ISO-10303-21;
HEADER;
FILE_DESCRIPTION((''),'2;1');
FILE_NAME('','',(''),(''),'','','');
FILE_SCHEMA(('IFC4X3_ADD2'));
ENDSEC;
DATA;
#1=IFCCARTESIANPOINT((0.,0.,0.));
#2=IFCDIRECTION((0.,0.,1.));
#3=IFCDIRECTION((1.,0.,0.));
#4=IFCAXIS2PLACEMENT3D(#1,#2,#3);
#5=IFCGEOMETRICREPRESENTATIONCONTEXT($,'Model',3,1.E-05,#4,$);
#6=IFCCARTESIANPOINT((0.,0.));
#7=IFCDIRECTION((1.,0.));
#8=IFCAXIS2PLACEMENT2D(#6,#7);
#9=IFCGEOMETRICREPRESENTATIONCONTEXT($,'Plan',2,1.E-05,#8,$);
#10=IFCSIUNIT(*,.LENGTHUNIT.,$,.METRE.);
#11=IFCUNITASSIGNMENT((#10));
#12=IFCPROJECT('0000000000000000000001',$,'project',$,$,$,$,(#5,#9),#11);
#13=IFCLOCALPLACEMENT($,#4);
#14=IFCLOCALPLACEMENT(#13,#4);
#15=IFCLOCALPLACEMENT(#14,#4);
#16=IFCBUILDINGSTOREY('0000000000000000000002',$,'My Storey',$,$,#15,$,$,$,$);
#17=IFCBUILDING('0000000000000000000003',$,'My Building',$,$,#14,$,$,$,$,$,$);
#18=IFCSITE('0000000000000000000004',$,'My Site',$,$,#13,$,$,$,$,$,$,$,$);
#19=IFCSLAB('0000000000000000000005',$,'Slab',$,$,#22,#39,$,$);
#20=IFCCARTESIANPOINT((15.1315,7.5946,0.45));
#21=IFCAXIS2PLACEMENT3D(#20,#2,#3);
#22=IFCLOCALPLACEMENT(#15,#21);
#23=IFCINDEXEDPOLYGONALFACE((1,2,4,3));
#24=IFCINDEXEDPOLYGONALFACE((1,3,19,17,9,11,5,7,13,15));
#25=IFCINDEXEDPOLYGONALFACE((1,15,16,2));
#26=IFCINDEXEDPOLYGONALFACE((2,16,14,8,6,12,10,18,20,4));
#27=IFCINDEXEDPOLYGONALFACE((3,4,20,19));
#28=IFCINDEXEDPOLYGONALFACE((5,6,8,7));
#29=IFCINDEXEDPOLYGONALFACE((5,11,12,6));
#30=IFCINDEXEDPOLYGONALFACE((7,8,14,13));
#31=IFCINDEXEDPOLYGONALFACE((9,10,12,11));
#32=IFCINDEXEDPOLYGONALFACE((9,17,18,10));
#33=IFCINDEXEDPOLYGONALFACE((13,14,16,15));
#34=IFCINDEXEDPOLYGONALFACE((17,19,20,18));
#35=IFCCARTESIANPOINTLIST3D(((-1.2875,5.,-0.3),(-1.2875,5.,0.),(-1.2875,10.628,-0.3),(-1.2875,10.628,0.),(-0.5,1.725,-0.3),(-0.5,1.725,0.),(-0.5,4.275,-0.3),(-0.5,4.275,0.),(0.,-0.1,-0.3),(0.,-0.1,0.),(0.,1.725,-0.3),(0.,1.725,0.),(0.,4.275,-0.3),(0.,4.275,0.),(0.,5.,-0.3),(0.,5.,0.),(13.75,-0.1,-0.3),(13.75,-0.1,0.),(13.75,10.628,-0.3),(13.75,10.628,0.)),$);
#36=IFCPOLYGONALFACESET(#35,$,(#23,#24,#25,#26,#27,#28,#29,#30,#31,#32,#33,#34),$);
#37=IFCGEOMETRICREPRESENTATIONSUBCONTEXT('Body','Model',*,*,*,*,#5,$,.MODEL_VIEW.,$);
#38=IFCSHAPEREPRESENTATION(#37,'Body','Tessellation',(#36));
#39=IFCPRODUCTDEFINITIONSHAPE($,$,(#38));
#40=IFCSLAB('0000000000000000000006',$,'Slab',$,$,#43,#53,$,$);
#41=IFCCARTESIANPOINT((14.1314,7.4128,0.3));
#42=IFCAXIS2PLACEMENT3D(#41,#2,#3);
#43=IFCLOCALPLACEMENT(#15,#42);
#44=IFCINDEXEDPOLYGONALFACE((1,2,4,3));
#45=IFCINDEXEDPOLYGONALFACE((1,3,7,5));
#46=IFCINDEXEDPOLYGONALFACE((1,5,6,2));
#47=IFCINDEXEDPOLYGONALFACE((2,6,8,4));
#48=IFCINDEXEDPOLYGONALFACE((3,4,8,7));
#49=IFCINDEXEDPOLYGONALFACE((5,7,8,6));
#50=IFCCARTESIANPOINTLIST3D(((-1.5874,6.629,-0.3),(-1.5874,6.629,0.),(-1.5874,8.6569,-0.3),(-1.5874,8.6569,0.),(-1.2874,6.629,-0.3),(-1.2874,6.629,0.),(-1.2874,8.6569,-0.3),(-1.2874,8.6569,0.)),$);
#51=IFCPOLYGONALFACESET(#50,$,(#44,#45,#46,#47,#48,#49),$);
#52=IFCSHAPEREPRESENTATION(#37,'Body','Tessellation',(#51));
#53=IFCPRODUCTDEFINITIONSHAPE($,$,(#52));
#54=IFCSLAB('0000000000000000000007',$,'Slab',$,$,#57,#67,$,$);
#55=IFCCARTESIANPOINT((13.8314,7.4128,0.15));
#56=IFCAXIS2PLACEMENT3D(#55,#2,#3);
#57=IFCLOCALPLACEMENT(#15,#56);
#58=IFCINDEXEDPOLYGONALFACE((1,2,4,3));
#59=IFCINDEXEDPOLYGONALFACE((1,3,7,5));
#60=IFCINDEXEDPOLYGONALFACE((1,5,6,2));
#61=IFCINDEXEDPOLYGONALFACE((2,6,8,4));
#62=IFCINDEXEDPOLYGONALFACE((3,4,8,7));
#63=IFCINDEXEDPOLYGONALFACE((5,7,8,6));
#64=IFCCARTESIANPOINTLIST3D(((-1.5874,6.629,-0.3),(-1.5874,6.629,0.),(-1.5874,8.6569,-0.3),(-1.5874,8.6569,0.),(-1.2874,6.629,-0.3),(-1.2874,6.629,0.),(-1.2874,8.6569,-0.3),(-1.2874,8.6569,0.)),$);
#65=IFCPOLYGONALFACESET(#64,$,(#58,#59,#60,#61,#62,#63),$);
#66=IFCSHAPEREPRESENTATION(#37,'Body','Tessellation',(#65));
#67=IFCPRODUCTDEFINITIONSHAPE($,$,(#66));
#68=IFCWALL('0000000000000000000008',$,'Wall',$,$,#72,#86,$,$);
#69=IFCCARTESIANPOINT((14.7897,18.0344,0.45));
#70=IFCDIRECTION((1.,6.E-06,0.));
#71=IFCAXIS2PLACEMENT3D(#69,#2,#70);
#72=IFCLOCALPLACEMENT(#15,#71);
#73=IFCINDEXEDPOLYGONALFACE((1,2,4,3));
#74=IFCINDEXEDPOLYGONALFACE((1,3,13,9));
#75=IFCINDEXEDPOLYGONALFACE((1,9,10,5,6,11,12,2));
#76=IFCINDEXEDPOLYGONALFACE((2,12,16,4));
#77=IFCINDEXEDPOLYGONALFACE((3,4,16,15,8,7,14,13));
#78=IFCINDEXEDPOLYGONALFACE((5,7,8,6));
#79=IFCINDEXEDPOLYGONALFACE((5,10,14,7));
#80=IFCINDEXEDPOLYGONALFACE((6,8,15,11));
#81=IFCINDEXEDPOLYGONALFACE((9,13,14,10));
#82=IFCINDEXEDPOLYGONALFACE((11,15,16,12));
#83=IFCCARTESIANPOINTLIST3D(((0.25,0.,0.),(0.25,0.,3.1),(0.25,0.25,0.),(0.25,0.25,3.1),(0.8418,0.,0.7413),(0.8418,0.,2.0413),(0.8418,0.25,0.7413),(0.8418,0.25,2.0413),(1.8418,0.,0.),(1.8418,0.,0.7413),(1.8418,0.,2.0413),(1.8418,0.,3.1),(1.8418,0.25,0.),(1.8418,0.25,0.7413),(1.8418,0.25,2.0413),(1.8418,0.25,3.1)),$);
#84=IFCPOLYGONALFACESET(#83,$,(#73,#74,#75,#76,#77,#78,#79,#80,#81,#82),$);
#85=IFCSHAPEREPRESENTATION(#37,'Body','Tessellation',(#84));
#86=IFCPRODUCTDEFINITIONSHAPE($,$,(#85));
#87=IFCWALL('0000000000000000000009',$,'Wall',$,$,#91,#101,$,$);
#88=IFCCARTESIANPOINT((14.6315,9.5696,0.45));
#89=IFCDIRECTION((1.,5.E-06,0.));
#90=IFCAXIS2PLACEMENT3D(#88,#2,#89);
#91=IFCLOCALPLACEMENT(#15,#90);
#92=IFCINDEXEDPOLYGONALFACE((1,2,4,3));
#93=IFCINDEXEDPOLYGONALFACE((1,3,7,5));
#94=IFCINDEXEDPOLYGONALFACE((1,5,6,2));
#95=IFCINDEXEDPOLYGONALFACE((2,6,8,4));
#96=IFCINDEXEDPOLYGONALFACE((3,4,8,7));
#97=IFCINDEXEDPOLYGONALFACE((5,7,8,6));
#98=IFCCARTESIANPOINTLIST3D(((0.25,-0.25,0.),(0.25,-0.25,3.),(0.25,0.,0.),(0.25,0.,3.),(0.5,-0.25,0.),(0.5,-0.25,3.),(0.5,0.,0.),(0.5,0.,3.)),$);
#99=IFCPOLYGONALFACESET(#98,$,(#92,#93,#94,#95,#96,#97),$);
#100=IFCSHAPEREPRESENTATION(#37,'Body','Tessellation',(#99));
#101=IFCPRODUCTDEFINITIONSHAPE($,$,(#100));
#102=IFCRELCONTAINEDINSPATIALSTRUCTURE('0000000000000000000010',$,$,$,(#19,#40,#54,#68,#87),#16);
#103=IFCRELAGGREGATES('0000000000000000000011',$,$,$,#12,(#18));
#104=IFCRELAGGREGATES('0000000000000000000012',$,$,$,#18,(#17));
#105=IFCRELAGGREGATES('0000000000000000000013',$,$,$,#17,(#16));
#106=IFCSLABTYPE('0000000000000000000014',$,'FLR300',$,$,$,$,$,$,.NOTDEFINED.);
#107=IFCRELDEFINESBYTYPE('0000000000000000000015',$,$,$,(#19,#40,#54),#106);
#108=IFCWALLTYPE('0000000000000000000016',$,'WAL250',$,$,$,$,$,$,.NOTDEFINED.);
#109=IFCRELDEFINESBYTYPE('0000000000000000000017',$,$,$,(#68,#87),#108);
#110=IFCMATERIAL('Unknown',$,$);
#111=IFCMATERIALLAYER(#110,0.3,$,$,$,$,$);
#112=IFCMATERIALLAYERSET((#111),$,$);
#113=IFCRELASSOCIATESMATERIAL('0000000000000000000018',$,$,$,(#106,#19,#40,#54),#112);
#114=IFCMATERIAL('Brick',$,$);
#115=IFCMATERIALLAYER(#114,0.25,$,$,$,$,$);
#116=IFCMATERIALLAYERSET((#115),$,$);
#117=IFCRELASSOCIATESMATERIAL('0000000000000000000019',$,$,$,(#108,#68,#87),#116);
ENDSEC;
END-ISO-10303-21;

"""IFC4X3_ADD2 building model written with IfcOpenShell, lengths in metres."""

from ifc_helpers import new_model, si_unit, frame, origin_with_axes, origin_2d_with_axis, place, context, subcontext, project, spatial, line, indexed_curve, outline, extrude, source, transform, mapped, material, layer, layer_set, layer_usage, type_object, element, save


model = new_model("IFC4X3_ADD2")

# Units and contexts
model_context = context("Model", 3, precision=1e-05, world=origin_with_axes())
plan_context = context("Plan", 2, precision=1e-05, world=origin_2d_with_axis())
body_context_1 = subcontext(model_context, "Body", "Model", "MODEL_VIEW")
ifc_project = project(units=[si_unit("LENGTHUNIT", "METRE")], contexts=[model_context, plan_context])

# Site, building, storey
site_placement = place(None, origin_with_axes())
site = spatial("IfcSite", under=ifc_project, at=site_placement, Name="My Site")
building_placement = place(site_placement, origin_with_axes())
building = spatial("IfcBuilding", under=site, at=building_placement, Name="My Building")
storey_placement = place(building_placement, origin_with_axes())
storey = spatial("IfcBuildingStorey", under=building, at=storey_placement, Name="My Storey")

# Shared definitions
ifc_material_1 = material(Name="Unknown")

# Slabs
ifc_layer_1 = layer(ifc_material_1, 0.3)
ifc_layer_set_1 = layer_set([ifc_layer_1])
ifc_layer_usage_1 = layer_usage(ifc_layer_set_1, "AXIS3", "POSITIVE", -0.3)
slab_type = type_object("IfcSlabType", Name="FLR300", PredefinedType="NOTDEFINED", material=ifc_layer_set_1)
slab_1_placement = place(storey_placement, frame((15.1315, 7.5946, 0.45), z_axis=(0.0, 0.0, 1.0), x_axis=(1.0, 0.0, 0.0)))
element("IfcSlab", 1, at=slab_1_placement, inside=storey, type_object=slab_type, material=ifc_layer_usage_1, Name="Slab", context=body_context_1, shape_type="SweptSolid", body=[
    extrude(outline(indexed_curve([(0.0, -0.1), (13.75, -0.1), (13.75, 10.628), (-1.2875, 10.628), (-1.2875, 5.0), (0.0, 5.0), (0.0, 4.275), (-0.5, 4.275), (-0.5, 1.725), (0.0, 1.725), (0.0, -0.1)])), frame((0.0, 0.0, -0.3), z_axis=(0.0, 0.0, 1.0), x_axis=(1.0, 0.0, 0.0)), (0.0, 0.0, 1.0), 0.3),
])
ifc_layer_usage_2 = layer_usage(ifc_layer_set_1, "AXIS3", "POSITIVE", -0.3)
slab_2_placement = place(storey_placement, frame((14.1314, 7.4128, 0.3), z_axis=(0.0, 0.0, 1.0), x_axis=(1.0, 0.0, 0.0)))
element("IfcSlab", 2, at=slab_2_placement, inside=storey, type_object=slab_type, material=ifc_layer_usage_2, Name="Slab", context=body_context_1, shape_type="SweptSolid", body=[
    extrude(outline(indexed_curve([(-1.2874, 6.629), (-1.2874, 8.6569), (-1.5874, 8.6569), (-1.5874, 6.629), (-1.2874, 6.629)])), frame((0.0, 0.0, -0.3), z_axis=(0.0, 0.0, 1.0), x_axis=(1.0, 0.0, 0.0)), (0.0, 0.0, 1.0), 0.3),
])
ifc_layer_usage_3 = layer_usage(ifc_layer_set_1, "AXIS3", "POSITIVE", -0.3)
slab_3_placement = place(storey_placement, frame((13.8314, 7.4128, 0.15), z_axis=(0.0, 0.0, 1.0), x_axis=(1.0, 0.0, 0.0)))
element("IfcSlab", 3, at=slab_3_placement, inside=storey, type_object=slab_type, material=ifc_layer_usage_3, Name="Slab", context=body_context_1, shape_type="SweptSolid", body=[
    extrude(outline(indexed_curve([(-1.5874, 6.629), (-1.5874, 8.6569), (-1.2874, 8.6569), (-1.2874, 6.629), (-1.5874, 6.629)])), frame((0.0, 0.0, -0.3), z_axis=(0.0, 0.0, 1.0), x_axis=(1.0, 0.0, 0.0)), (0.0, 0.0, 1.0), 0.3),
])

# Shared definitions
ifc_material_2 = material(Name="Brick")

# Wall, opening
ifc_layer_2 = layer(ifc_material_2, 0.25)
ifc_layer_set_2 = layer_set([ifc_layer_2])
ifc_layer_usage_4 = layer_usage(ifc_layer_set_2, "AXIS2", "POSITIVE", 0.0)
wall_type_1 = type_object("IfcWallType", Name="WAL250", PredefinedType="NOTDEFINED", material=ifc_layer_set_2)
wall_1_placement = place(storey_placement, frame((14.7897, 18.0344, 0.45), z_axis=(0.0, 0.0, 1.0), x_axis=(1.0, 0.000006, 0.0)))
wall_1 = element("IfcWall", 4, at=wall_1_placement, inside=storey, type_object=wall_type_1, material=ifc_layer_usage_4, Name="Wall", context=body_context_1, shape_type="SweptSolid", body=[
    extrude(outline(indexed_curve([(0.25, 0.0), (0.25, 0.25), (1.8418, 0.25), (1.8418, 0.0)], segments=[line(1, 2, 3, 4, 1)])), origin_with_axes(), (0.0, 0.0, 1.0), 3.1),
])
shared_shape_1 = source(origin_with_axes(), body_context_1, "Body", "SweptSolid", [
    extrude(outline(indexed_curve([(0.0, 0.0), (1.0, 0.0), (1.0, 1.3), (0.0, 1.3)], segments=[line(1, 2, 3, 4, 1)])), frame((0.0, -0.6, 0.0), z_axis=(0.0, -1.0, 0.0), x_axis=(1.0, 0.0, 0.0)), (0.0, 0.0, -1.0), 1.2),
])
opening_1_placement = place(wall_1_placement, frame((0.8418, 0.0, 0.7413), z_axis=(0.0, 0.0, 1.0), x_axis=(1.0, 0.0, 0.0)))
element("IfcOpeningElement", 5, at=opening_1_placement, cuts=wall_1, PredefinedType="OPENING", context=body_context_1, shape_type="MappedRepresentation", body=[
    mapped(shared_shape_1, transform((0.0, 0.0, 0.0), x_axis=(1.0, 0.0, 0.0), y_axis=(0.0, 1.0, 0.0), z_axis=(0.0, 0.0, 1.0), scale=1.0)),
])

# Wall
ifc_layer_usage_5 = layer_usage(ifc_layer_set_2, "AXIS2", "NEGATIVE", 0.0)
wall_2_placement = place(storey_placement, frame((14.6315, 9.5696, 0.45), z_axis=(0.0, 0.0, 1.0), x_axis=(1.0, 0.000005, 0.0)))
element("IfcWall", 6, at=wall_2_placement, inside=storey, type_object=wall_type_1, material=ifc_layer_usage_5, Name="Wall", context=body_context_1, shape_type="SweptSolid", body=[
    extrude(outline(indexed_curve([(0.25, -0.25), (0.25, 0.0), (0.5, 0.0), (0.5, -0.25)], segments=[line(1, 2, 3, 4, 1)])), origin_with_axes(), (0.0, 0.0, 1.0), 3.0),
])

save(model, "model.ifc")
